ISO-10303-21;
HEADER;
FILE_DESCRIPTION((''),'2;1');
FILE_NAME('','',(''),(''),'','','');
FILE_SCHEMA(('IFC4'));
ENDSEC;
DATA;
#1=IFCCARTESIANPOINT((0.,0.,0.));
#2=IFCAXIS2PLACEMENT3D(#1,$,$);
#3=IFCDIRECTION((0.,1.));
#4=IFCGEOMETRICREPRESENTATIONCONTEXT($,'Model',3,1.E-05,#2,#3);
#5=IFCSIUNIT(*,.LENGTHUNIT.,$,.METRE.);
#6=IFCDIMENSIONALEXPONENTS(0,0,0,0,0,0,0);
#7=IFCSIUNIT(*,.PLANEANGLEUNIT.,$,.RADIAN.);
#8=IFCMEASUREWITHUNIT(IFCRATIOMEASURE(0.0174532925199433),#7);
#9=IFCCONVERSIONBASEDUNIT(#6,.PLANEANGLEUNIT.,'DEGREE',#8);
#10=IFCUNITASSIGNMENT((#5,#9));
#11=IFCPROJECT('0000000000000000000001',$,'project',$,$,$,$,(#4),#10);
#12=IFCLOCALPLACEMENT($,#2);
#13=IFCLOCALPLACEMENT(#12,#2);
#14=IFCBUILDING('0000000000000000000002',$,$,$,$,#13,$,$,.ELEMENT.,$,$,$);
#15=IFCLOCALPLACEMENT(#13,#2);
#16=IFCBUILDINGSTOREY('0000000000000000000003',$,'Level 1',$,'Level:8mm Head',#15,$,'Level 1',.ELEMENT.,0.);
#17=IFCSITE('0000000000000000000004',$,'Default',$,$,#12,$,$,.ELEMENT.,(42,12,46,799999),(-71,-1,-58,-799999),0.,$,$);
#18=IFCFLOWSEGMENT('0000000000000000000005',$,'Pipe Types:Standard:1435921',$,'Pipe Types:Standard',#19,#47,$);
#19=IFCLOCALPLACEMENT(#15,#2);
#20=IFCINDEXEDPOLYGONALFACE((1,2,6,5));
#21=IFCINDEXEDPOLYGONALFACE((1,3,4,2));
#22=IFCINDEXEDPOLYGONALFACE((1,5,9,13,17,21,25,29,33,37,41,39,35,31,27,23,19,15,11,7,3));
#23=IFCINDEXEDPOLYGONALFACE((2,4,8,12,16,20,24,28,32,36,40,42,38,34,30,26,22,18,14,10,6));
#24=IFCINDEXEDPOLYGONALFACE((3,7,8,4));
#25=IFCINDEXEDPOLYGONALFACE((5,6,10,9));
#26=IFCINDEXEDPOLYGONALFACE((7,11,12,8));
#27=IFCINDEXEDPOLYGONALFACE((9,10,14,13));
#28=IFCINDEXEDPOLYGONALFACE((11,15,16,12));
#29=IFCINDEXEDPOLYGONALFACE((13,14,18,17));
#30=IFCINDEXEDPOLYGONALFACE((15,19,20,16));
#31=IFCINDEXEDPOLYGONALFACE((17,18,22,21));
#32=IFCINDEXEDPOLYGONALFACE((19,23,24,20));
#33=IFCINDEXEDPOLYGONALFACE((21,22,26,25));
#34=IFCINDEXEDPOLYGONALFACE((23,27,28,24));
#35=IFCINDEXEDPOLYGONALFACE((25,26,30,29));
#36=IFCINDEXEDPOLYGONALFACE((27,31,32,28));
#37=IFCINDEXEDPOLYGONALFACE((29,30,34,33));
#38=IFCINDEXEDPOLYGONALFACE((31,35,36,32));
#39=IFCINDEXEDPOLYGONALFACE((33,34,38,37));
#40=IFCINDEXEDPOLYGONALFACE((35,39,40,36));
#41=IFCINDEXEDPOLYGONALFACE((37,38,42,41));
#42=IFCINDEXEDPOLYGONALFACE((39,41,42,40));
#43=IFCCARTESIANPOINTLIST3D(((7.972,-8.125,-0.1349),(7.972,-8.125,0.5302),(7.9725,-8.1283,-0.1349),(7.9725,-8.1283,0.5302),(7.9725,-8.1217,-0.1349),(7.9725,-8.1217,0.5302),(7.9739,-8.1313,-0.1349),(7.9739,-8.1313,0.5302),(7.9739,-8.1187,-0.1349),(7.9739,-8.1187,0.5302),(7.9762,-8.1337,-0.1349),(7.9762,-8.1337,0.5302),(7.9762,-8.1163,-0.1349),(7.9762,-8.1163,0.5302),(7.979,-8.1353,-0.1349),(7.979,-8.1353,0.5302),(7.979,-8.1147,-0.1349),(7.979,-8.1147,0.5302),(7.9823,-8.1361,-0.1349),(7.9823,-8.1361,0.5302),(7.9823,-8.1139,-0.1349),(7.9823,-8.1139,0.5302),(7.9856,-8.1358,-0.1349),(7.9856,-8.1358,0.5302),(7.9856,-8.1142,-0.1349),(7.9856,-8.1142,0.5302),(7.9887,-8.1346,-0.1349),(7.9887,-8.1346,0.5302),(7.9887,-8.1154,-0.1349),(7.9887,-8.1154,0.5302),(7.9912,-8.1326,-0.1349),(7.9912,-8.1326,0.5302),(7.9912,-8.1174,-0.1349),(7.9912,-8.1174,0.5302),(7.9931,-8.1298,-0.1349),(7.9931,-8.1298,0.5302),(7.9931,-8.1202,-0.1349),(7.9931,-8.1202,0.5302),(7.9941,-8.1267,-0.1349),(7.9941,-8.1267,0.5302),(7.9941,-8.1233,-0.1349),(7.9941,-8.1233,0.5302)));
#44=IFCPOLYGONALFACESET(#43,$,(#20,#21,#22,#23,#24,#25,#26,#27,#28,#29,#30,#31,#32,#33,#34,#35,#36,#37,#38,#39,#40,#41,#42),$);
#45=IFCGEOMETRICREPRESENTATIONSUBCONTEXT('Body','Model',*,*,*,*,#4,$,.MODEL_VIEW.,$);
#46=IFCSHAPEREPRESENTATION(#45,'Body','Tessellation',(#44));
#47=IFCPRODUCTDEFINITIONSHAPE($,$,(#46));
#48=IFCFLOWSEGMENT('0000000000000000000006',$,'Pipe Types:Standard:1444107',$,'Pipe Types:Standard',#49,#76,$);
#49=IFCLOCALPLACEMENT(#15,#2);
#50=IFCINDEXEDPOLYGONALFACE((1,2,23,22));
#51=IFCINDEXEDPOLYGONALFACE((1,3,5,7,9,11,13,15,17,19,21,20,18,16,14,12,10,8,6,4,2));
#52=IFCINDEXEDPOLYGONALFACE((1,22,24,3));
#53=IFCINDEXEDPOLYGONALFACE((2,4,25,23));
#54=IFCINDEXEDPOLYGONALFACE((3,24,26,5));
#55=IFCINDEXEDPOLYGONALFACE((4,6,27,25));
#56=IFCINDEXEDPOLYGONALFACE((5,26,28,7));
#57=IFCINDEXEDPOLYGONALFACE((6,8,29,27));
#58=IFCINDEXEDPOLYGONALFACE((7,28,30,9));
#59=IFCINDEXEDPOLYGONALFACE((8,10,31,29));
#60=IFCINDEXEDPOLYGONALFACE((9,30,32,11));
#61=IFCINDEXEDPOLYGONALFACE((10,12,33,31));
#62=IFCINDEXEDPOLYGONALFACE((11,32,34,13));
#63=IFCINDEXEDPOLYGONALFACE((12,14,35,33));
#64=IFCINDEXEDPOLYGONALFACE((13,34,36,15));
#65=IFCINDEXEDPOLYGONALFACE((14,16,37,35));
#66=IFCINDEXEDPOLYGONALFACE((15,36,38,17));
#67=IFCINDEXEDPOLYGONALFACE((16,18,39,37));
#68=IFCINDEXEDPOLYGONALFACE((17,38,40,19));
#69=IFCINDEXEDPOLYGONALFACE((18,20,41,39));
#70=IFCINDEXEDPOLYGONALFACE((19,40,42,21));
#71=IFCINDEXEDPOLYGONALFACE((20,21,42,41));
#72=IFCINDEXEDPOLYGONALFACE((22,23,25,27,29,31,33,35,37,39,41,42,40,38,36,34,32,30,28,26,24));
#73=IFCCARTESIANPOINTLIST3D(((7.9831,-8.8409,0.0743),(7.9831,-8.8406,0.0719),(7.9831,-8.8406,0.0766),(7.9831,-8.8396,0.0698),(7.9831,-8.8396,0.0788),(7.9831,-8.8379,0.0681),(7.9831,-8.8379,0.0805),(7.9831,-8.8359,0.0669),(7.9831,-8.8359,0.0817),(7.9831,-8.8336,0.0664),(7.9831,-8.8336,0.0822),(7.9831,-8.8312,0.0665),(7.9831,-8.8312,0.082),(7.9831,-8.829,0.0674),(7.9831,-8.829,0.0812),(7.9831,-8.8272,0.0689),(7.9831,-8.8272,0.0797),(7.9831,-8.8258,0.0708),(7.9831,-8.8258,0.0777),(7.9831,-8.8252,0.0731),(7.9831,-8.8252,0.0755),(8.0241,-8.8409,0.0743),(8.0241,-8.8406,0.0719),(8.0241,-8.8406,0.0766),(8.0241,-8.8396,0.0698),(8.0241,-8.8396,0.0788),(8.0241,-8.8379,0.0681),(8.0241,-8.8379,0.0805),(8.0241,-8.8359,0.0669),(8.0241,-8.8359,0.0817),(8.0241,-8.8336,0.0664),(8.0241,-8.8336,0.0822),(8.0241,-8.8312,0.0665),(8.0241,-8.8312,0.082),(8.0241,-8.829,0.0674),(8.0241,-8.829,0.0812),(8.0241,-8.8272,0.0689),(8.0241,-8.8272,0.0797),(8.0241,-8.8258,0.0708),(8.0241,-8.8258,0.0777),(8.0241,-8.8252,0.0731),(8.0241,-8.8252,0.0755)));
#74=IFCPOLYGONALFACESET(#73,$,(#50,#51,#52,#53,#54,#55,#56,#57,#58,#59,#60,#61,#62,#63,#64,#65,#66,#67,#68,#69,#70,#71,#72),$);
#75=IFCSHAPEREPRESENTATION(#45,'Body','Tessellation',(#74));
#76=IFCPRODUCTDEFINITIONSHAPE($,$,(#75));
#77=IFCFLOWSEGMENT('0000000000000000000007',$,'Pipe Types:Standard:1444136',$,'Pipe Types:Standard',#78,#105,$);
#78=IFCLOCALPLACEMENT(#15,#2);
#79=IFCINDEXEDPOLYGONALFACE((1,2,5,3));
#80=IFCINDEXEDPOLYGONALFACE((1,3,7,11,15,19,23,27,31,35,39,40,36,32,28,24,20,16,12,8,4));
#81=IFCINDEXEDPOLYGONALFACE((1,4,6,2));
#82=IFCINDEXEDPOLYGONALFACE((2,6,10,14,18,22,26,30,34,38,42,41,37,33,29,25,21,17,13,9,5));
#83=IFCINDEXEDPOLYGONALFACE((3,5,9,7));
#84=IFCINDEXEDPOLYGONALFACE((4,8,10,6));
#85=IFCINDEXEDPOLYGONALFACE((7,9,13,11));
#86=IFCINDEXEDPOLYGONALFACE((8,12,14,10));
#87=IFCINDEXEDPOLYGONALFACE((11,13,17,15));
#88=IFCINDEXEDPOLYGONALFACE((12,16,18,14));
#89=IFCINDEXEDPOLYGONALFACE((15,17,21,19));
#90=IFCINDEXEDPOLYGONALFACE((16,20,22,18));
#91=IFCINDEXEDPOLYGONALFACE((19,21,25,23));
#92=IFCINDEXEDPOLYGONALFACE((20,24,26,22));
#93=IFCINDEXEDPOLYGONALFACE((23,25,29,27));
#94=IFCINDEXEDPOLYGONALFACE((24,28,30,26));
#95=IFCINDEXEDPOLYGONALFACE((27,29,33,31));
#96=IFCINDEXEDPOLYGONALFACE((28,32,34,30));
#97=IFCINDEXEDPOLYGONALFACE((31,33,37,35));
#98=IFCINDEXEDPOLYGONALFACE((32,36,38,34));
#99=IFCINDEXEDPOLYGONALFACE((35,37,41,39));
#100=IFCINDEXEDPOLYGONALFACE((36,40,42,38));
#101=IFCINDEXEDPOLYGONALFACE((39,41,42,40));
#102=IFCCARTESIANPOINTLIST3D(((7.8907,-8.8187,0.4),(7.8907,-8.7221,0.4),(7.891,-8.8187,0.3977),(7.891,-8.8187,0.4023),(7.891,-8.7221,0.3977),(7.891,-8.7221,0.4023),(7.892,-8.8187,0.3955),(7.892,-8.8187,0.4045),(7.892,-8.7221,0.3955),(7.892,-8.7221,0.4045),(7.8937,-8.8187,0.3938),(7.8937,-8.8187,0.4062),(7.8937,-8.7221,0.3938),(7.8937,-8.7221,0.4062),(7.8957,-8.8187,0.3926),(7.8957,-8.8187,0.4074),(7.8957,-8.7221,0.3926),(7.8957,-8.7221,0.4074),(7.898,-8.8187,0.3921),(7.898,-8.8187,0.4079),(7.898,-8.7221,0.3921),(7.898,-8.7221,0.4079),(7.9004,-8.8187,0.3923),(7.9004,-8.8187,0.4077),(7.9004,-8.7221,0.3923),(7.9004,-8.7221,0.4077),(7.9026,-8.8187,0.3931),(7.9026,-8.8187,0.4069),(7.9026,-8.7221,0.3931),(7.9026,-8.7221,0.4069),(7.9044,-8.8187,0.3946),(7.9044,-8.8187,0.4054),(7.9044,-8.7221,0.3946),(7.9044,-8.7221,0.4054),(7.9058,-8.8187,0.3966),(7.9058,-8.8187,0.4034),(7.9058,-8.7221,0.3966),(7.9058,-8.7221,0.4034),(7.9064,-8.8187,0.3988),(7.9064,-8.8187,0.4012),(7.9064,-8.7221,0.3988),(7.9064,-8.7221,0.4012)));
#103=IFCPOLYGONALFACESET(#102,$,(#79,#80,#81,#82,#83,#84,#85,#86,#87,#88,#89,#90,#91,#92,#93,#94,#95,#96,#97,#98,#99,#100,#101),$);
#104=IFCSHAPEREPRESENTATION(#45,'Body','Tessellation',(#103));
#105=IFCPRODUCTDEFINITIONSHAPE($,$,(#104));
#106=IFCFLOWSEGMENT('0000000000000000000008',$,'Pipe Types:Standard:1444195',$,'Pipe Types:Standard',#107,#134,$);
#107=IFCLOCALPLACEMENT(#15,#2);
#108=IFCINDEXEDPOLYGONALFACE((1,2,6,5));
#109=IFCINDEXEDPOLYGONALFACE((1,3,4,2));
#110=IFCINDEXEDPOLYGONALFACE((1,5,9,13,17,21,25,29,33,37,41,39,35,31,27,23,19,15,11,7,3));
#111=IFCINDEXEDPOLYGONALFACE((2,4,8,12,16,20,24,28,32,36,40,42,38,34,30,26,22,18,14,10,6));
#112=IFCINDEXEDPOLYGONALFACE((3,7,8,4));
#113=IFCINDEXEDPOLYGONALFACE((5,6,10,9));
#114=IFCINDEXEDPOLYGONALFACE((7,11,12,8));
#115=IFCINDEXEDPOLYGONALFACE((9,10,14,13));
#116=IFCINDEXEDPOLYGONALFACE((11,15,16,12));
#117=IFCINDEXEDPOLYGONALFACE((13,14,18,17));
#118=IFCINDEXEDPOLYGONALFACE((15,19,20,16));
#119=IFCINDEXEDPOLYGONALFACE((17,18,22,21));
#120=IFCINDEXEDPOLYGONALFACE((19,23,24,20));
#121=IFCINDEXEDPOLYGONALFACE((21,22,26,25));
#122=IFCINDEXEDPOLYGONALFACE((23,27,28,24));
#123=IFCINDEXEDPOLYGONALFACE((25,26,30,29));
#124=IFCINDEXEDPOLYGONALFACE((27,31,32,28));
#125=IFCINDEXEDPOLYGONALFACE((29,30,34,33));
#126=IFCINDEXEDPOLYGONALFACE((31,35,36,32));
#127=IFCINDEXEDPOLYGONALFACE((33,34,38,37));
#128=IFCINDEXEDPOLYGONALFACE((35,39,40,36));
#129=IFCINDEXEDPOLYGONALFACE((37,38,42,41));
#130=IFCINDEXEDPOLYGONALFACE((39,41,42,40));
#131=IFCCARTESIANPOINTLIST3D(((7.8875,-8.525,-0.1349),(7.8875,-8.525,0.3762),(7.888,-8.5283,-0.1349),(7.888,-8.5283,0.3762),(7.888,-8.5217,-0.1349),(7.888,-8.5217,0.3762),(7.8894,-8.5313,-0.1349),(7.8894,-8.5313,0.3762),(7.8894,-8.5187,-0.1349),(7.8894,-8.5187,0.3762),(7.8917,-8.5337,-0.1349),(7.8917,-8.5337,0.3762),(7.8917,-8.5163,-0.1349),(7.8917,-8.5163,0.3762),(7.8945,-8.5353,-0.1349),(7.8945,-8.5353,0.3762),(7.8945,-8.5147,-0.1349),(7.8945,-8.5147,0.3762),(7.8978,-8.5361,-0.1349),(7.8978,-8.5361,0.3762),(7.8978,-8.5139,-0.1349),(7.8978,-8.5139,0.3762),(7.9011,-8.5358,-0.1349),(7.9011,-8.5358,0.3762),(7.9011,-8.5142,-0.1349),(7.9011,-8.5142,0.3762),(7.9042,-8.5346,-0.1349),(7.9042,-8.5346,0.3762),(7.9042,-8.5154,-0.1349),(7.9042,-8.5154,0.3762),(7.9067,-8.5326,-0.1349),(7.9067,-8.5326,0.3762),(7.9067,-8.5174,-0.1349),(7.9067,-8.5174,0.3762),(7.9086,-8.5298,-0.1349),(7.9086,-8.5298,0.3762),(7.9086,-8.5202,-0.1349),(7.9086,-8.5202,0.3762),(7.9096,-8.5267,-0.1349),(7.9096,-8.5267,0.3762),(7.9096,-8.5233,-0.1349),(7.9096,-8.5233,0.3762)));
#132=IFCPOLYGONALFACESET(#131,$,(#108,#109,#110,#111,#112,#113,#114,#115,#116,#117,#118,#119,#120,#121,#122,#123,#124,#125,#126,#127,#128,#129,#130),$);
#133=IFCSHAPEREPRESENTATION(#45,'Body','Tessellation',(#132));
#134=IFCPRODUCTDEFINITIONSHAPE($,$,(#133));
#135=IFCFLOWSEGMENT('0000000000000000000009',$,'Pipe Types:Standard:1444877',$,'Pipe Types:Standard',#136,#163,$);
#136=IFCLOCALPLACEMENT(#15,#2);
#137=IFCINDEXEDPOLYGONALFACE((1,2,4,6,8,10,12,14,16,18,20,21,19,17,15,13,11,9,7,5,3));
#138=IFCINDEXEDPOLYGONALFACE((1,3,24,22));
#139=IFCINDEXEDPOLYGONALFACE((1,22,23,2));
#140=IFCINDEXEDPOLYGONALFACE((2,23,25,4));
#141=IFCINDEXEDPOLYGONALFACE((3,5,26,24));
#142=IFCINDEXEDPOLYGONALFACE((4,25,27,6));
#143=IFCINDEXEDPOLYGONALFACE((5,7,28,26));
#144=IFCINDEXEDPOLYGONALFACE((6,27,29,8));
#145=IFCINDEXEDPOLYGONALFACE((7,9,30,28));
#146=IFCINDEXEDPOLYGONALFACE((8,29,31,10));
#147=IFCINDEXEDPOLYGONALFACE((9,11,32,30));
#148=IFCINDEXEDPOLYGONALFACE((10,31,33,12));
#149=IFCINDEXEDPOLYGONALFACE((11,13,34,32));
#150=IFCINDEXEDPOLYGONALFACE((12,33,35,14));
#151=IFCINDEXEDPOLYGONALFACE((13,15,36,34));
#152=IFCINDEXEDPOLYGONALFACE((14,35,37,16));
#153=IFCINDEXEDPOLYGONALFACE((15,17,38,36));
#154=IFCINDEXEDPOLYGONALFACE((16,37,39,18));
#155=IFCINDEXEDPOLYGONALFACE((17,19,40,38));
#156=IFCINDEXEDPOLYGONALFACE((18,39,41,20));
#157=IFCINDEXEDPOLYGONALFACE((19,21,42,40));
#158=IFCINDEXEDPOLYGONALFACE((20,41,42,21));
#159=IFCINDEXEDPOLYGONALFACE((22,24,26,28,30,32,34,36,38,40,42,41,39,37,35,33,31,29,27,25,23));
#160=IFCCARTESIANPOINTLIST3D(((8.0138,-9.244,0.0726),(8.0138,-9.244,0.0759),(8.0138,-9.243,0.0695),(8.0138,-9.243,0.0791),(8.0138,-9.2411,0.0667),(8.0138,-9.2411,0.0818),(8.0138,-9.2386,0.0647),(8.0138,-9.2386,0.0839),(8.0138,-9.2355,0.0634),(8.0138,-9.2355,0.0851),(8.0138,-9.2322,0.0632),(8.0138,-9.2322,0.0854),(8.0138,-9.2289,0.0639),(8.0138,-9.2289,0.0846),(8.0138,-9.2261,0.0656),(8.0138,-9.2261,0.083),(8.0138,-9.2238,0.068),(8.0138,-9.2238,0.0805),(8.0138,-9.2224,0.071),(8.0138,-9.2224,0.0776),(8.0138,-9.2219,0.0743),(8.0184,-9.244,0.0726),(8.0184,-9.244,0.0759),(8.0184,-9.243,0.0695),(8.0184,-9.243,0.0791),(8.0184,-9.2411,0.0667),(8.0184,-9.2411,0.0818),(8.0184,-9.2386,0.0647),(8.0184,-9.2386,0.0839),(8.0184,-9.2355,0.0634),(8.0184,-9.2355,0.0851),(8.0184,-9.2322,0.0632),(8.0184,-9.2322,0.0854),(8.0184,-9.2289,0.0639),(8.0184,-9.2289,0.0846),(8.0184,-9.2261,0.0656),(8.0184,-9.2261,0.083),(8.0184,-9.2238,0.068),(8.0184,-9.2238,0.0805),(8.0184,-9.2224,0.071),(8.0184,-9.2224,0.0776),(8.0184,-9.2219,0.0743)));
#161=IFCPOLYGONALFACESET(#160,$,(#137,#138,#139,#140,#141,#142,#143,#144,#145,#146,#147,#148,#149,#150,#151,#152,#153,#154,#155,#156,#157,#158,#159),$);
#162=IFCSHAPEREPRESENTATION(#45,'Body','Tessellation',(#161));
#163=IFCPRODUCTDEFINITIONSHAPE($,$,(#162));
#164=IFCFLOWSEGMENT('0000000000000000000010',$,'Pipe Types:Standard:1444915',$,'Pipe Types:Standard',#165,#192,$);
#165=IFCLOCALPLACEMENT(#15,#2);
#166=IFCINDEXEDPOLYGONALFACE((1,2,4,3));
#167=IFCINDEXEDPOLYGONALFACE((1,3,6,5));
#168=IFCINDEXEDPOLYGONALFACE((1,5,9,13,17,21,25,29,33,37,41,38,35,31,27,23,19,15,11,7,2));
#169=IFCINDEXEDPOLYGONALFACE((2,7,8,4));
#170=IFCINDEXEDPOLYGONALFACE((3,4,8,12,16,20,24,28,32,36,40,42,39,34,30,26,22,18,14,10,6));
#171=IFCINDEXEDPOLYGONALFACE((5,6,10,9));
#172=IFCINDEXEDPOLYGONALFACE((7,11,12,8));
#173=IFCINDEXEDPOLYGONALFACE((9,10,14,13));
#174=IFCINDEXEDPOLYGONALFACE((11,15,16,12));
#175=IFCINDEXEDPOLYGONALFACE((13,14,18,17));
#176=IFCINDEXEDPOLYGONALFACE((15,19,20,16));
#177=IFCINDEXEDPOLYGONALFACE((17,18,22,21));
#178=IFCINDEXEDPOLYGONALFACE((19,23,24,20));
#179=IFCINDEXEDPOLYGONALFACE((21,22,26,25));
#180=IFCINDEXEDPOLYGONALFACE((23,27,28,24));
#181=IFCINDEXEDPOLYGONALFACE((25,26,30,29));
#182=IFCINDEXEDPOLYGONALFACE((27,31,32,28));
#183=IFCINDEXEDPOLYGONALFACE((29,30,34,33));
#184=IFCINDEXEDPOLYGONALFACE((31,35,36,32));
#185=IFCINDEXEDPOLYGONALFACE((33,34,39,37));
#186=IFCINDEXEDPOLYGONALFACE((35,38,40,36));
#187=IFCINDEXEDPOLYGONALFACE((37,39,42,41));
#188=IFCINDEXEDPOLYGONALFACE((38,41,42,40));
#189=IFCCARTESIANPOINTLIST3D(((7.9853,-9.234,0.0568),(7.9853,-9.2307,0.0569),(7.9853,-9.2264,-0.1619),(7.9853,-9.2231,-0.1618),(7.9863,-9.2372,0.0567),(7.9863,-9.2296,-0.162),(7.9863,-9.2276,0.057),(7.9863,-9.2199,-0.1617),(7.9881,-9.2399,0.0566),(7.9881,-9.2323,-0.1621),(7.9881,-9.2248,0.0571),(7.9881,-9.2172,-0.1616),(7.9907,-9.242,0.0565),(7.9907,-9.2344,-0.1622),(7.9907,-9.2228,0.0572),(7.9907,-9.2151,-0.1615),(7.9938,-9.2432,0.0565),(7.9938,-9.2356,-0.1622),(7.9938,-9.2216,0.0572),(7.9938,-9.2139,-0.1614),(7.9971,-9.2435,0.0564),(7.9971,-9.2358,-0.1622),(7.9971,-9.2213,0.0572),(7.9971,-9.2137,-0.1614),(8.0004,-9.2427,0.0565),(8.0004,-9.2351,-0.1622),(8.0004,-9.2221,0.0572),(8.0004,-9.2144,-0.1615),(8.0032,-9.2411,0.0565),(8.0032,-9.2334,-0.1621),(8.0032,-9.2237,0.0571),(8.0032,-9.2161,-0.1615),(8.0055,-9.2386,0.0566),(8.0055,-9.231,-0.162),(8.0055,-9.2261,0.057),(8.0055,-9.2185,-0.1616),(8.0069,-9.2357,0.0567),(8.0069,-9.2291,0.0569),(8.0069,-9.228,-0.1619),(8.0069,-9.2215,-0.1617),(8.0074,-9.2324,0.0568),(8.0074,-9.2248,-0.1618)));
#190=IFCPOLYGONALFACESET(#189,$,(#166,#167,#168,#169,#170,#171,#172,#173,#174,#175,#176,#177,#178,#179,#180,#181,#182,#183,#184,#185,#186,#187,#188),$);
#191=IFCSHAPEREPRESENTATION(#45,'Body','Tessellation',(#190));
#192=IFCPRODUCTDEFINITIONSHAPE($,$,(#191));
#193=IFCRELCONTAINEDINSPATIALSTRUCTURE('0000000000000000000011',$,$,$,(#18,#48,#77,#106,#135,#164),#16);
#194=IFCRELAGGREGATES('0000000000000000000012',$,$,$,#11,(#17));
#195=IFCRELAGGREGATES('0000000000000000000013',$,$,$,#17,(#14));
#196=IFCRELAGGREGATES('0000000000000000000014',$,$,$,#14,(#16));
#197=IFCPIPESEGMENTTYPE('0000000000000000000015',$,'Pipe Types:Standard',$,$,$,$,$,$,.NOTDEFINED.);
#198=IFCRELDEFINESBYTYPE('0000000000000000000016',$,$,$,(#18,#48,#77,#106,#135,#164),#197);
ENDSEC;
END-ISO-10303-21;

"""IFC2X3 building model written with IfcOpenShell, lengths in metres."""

from ifc_helpers import new_model, entity, si_unit, converted_unit, direction, frame, frame_2d, origin, origin_2d_with_axis, place, context, subcontext, project, spatial, circle, extrude, type_object, element, save


model = new_model("IFC2X3")

# Units and contexts
model_context = context("Model", 3, precision=1e-05, world=origin(), true_north=direction((0.0, 1.0)))
body_context = subcontext(model_context, "Body", "Model", "MODEL_VIEW")
ifc_project = project(units=[si_unit("LENGTHUNIT", "METRE"), converted_unit("PLANEANGLEUNIT", "DEGREE", entity("IfcRatioMeasure", 0.0174532925199433), si_unit("PLANEANGLEUNIT", "RADIAN"), dimensions=[0, 0, 0, 0, 0, 0, 0])], contexts=[model_context])

# Site, building, storey
site_placement = place(None, origin())
site = spatial("IfcSite", under=ifc_project, at=site_placement, Name="Default", CompositionType="ELEMENT", RefLatitude=(42, 12, 46, 799999), RefLongitude=(-71, -1, -58, -799999), RefElevation=0.0)
building_placement = place(site_placement, origin())
building = spatial("IfcBuilding", under=site, at=building_placement, CompositionType="ELEMENT")
storey_placement = place(building_placement, origin())
storey = spatial("IfcBuildingStorey", under=building, at=storey_placement, Name="Level 1", ObjectType="Level:8mm Head", LongName="Level 1", CompositionType="ELEMENT", Elevation=0.0)

# Flow segments
pipe_segment_type = type_object("IfcPipeSegmentType", Name="Pipe Types:Standard", PredefinedType="NOTDEFINED")
flow_segment_1_placement = place(storey_placement, origin())
element("IfcFlowSegment", 1, at=flow_segment_1_placement, inside=storey, type_object=pipe_segment_type, Name="Pipe Types:Standard:1435921", ObjectType="Pipe Types:Standard", context=body_context, shape_type="SweptSolid", body=[
    extrude(circle(Radius=0.0111, at=frame_2d((0.0, 0.0), x_axis=(1.0, 0.0))), frame((7.9831, -8.125, -0.1349), z_axis=(0.0, 0.0, 1.0), x_axis=(-1.0, 0.0, 0.0)), (0.0, 0.0, 1.0), 0.6651),
])
flow_segment_2_placement = place(storey_placement, origin())
element("IfcFlowSegment", 2, at=flow_segment_2_placement, inside=storey, type_object=pipe_segment_type, Name="Pipe Types:Standard:1444107", ObjectType="Pipe Types:Standard", context=body_context, shape_type="SweptSolid", body=[
    extrude(circle(Radius=0.0079, at=frame_2d((0.0, 0.0), x_axis=(1.0, 0.0))), frame((7.9831, -8.833, 0.0743), z_axis=(1.0, 0.0, -0.000175), x_axis=(0.0, -1.0, 0.0)), (0.0, 0.0, 1.0), 0.041),
])
flow_segment_3_placement = place(storey_placement, origin())
element("IfcFlowSegment", 3, at=flow_segment_3_placement, inside=storey, type_object=pipe_segment_type, Name="Pipe Types:Standard:1444136", ObjectType="Pipe Types:Standard", context=body_context, shape_type="SweptSolid", body=[
    extrude(circle(Radius=0.0079, at=frame_2d((0.0, 0.0), x_axis=(1.0, 0.0))), frame((7.8986, -8.8187, 0.4), z_axis=(0.0, 1.0, 0.0), x_axis=(-1.0, 0.0, 0.0)), (0.0, 0.0, 1.0), 0.0966),
])
flow_segment_4_placement = place(storey_placement, origin())
element("IfcFlowSegment", 4, at=flow_segment_4_placement, inside=storey, type_object=pipe_segment_type, Name="Pipe Types:Standard:1444195", ObjectType="Pipe Types:Standard", context=body_context, shape_type="SweptSolid", body=[
    extrude(circle(Radius=0.0111, at=origin_2d_with_axis()), frame((7.8986, -8.525, -0.1349), z_axis=(0.0, 0.0, 1.0), x_axis=(-1.0, 0.0, 0.0)), (0.0, 0.0, 1.0), 0.5111),
])
flow_segment_5_placement = place(storey_placement, origin())
element("IfcFlowSegment", 5, at=flow_segment_5_placement, inside=storey, type_object=pipe_segment_type, Name="Pipe Types:Standard:1444877", ObjectType="Pipe Types:Standard", context=body_context, shape_type="SweptSolid", body=[
    extrude(circle(Radius=0.0111, at=frame_2d((0.0, 0.0), x_axis=(1.0, 0.0))), frame((8.0138, -9.233, 0.0743), z_axis=(1.0, 0.0, 0.0), x_axis=(0.0, 1.0, 0.0)), (0.0, 0.0, 1.0), 0.0046),
])
flow_segment_6_placement = place(storey_placement, origin())
element("IfcFlowSegment", 6, at=flow_segment_6_placement, inside=storey, type_object=pipe_segment_type, Name="Pipe Types:Standard:1444915", ObjectType="Pipe Types:Standard", context=body_context, shape_type="SweptSolid", body=[
    extrude(circle(Radius=0.0111, at=origin_2d_with_axis()), frame((7.9963, -9.2324, 0.0568), z_axis=(0.0, 0.034899, -0.999391), x_axis=(1.0, 0.0, 0.0)), (0.0, 0.0, 1.0), 0.2188),
])

save(model, "model.ifc")
